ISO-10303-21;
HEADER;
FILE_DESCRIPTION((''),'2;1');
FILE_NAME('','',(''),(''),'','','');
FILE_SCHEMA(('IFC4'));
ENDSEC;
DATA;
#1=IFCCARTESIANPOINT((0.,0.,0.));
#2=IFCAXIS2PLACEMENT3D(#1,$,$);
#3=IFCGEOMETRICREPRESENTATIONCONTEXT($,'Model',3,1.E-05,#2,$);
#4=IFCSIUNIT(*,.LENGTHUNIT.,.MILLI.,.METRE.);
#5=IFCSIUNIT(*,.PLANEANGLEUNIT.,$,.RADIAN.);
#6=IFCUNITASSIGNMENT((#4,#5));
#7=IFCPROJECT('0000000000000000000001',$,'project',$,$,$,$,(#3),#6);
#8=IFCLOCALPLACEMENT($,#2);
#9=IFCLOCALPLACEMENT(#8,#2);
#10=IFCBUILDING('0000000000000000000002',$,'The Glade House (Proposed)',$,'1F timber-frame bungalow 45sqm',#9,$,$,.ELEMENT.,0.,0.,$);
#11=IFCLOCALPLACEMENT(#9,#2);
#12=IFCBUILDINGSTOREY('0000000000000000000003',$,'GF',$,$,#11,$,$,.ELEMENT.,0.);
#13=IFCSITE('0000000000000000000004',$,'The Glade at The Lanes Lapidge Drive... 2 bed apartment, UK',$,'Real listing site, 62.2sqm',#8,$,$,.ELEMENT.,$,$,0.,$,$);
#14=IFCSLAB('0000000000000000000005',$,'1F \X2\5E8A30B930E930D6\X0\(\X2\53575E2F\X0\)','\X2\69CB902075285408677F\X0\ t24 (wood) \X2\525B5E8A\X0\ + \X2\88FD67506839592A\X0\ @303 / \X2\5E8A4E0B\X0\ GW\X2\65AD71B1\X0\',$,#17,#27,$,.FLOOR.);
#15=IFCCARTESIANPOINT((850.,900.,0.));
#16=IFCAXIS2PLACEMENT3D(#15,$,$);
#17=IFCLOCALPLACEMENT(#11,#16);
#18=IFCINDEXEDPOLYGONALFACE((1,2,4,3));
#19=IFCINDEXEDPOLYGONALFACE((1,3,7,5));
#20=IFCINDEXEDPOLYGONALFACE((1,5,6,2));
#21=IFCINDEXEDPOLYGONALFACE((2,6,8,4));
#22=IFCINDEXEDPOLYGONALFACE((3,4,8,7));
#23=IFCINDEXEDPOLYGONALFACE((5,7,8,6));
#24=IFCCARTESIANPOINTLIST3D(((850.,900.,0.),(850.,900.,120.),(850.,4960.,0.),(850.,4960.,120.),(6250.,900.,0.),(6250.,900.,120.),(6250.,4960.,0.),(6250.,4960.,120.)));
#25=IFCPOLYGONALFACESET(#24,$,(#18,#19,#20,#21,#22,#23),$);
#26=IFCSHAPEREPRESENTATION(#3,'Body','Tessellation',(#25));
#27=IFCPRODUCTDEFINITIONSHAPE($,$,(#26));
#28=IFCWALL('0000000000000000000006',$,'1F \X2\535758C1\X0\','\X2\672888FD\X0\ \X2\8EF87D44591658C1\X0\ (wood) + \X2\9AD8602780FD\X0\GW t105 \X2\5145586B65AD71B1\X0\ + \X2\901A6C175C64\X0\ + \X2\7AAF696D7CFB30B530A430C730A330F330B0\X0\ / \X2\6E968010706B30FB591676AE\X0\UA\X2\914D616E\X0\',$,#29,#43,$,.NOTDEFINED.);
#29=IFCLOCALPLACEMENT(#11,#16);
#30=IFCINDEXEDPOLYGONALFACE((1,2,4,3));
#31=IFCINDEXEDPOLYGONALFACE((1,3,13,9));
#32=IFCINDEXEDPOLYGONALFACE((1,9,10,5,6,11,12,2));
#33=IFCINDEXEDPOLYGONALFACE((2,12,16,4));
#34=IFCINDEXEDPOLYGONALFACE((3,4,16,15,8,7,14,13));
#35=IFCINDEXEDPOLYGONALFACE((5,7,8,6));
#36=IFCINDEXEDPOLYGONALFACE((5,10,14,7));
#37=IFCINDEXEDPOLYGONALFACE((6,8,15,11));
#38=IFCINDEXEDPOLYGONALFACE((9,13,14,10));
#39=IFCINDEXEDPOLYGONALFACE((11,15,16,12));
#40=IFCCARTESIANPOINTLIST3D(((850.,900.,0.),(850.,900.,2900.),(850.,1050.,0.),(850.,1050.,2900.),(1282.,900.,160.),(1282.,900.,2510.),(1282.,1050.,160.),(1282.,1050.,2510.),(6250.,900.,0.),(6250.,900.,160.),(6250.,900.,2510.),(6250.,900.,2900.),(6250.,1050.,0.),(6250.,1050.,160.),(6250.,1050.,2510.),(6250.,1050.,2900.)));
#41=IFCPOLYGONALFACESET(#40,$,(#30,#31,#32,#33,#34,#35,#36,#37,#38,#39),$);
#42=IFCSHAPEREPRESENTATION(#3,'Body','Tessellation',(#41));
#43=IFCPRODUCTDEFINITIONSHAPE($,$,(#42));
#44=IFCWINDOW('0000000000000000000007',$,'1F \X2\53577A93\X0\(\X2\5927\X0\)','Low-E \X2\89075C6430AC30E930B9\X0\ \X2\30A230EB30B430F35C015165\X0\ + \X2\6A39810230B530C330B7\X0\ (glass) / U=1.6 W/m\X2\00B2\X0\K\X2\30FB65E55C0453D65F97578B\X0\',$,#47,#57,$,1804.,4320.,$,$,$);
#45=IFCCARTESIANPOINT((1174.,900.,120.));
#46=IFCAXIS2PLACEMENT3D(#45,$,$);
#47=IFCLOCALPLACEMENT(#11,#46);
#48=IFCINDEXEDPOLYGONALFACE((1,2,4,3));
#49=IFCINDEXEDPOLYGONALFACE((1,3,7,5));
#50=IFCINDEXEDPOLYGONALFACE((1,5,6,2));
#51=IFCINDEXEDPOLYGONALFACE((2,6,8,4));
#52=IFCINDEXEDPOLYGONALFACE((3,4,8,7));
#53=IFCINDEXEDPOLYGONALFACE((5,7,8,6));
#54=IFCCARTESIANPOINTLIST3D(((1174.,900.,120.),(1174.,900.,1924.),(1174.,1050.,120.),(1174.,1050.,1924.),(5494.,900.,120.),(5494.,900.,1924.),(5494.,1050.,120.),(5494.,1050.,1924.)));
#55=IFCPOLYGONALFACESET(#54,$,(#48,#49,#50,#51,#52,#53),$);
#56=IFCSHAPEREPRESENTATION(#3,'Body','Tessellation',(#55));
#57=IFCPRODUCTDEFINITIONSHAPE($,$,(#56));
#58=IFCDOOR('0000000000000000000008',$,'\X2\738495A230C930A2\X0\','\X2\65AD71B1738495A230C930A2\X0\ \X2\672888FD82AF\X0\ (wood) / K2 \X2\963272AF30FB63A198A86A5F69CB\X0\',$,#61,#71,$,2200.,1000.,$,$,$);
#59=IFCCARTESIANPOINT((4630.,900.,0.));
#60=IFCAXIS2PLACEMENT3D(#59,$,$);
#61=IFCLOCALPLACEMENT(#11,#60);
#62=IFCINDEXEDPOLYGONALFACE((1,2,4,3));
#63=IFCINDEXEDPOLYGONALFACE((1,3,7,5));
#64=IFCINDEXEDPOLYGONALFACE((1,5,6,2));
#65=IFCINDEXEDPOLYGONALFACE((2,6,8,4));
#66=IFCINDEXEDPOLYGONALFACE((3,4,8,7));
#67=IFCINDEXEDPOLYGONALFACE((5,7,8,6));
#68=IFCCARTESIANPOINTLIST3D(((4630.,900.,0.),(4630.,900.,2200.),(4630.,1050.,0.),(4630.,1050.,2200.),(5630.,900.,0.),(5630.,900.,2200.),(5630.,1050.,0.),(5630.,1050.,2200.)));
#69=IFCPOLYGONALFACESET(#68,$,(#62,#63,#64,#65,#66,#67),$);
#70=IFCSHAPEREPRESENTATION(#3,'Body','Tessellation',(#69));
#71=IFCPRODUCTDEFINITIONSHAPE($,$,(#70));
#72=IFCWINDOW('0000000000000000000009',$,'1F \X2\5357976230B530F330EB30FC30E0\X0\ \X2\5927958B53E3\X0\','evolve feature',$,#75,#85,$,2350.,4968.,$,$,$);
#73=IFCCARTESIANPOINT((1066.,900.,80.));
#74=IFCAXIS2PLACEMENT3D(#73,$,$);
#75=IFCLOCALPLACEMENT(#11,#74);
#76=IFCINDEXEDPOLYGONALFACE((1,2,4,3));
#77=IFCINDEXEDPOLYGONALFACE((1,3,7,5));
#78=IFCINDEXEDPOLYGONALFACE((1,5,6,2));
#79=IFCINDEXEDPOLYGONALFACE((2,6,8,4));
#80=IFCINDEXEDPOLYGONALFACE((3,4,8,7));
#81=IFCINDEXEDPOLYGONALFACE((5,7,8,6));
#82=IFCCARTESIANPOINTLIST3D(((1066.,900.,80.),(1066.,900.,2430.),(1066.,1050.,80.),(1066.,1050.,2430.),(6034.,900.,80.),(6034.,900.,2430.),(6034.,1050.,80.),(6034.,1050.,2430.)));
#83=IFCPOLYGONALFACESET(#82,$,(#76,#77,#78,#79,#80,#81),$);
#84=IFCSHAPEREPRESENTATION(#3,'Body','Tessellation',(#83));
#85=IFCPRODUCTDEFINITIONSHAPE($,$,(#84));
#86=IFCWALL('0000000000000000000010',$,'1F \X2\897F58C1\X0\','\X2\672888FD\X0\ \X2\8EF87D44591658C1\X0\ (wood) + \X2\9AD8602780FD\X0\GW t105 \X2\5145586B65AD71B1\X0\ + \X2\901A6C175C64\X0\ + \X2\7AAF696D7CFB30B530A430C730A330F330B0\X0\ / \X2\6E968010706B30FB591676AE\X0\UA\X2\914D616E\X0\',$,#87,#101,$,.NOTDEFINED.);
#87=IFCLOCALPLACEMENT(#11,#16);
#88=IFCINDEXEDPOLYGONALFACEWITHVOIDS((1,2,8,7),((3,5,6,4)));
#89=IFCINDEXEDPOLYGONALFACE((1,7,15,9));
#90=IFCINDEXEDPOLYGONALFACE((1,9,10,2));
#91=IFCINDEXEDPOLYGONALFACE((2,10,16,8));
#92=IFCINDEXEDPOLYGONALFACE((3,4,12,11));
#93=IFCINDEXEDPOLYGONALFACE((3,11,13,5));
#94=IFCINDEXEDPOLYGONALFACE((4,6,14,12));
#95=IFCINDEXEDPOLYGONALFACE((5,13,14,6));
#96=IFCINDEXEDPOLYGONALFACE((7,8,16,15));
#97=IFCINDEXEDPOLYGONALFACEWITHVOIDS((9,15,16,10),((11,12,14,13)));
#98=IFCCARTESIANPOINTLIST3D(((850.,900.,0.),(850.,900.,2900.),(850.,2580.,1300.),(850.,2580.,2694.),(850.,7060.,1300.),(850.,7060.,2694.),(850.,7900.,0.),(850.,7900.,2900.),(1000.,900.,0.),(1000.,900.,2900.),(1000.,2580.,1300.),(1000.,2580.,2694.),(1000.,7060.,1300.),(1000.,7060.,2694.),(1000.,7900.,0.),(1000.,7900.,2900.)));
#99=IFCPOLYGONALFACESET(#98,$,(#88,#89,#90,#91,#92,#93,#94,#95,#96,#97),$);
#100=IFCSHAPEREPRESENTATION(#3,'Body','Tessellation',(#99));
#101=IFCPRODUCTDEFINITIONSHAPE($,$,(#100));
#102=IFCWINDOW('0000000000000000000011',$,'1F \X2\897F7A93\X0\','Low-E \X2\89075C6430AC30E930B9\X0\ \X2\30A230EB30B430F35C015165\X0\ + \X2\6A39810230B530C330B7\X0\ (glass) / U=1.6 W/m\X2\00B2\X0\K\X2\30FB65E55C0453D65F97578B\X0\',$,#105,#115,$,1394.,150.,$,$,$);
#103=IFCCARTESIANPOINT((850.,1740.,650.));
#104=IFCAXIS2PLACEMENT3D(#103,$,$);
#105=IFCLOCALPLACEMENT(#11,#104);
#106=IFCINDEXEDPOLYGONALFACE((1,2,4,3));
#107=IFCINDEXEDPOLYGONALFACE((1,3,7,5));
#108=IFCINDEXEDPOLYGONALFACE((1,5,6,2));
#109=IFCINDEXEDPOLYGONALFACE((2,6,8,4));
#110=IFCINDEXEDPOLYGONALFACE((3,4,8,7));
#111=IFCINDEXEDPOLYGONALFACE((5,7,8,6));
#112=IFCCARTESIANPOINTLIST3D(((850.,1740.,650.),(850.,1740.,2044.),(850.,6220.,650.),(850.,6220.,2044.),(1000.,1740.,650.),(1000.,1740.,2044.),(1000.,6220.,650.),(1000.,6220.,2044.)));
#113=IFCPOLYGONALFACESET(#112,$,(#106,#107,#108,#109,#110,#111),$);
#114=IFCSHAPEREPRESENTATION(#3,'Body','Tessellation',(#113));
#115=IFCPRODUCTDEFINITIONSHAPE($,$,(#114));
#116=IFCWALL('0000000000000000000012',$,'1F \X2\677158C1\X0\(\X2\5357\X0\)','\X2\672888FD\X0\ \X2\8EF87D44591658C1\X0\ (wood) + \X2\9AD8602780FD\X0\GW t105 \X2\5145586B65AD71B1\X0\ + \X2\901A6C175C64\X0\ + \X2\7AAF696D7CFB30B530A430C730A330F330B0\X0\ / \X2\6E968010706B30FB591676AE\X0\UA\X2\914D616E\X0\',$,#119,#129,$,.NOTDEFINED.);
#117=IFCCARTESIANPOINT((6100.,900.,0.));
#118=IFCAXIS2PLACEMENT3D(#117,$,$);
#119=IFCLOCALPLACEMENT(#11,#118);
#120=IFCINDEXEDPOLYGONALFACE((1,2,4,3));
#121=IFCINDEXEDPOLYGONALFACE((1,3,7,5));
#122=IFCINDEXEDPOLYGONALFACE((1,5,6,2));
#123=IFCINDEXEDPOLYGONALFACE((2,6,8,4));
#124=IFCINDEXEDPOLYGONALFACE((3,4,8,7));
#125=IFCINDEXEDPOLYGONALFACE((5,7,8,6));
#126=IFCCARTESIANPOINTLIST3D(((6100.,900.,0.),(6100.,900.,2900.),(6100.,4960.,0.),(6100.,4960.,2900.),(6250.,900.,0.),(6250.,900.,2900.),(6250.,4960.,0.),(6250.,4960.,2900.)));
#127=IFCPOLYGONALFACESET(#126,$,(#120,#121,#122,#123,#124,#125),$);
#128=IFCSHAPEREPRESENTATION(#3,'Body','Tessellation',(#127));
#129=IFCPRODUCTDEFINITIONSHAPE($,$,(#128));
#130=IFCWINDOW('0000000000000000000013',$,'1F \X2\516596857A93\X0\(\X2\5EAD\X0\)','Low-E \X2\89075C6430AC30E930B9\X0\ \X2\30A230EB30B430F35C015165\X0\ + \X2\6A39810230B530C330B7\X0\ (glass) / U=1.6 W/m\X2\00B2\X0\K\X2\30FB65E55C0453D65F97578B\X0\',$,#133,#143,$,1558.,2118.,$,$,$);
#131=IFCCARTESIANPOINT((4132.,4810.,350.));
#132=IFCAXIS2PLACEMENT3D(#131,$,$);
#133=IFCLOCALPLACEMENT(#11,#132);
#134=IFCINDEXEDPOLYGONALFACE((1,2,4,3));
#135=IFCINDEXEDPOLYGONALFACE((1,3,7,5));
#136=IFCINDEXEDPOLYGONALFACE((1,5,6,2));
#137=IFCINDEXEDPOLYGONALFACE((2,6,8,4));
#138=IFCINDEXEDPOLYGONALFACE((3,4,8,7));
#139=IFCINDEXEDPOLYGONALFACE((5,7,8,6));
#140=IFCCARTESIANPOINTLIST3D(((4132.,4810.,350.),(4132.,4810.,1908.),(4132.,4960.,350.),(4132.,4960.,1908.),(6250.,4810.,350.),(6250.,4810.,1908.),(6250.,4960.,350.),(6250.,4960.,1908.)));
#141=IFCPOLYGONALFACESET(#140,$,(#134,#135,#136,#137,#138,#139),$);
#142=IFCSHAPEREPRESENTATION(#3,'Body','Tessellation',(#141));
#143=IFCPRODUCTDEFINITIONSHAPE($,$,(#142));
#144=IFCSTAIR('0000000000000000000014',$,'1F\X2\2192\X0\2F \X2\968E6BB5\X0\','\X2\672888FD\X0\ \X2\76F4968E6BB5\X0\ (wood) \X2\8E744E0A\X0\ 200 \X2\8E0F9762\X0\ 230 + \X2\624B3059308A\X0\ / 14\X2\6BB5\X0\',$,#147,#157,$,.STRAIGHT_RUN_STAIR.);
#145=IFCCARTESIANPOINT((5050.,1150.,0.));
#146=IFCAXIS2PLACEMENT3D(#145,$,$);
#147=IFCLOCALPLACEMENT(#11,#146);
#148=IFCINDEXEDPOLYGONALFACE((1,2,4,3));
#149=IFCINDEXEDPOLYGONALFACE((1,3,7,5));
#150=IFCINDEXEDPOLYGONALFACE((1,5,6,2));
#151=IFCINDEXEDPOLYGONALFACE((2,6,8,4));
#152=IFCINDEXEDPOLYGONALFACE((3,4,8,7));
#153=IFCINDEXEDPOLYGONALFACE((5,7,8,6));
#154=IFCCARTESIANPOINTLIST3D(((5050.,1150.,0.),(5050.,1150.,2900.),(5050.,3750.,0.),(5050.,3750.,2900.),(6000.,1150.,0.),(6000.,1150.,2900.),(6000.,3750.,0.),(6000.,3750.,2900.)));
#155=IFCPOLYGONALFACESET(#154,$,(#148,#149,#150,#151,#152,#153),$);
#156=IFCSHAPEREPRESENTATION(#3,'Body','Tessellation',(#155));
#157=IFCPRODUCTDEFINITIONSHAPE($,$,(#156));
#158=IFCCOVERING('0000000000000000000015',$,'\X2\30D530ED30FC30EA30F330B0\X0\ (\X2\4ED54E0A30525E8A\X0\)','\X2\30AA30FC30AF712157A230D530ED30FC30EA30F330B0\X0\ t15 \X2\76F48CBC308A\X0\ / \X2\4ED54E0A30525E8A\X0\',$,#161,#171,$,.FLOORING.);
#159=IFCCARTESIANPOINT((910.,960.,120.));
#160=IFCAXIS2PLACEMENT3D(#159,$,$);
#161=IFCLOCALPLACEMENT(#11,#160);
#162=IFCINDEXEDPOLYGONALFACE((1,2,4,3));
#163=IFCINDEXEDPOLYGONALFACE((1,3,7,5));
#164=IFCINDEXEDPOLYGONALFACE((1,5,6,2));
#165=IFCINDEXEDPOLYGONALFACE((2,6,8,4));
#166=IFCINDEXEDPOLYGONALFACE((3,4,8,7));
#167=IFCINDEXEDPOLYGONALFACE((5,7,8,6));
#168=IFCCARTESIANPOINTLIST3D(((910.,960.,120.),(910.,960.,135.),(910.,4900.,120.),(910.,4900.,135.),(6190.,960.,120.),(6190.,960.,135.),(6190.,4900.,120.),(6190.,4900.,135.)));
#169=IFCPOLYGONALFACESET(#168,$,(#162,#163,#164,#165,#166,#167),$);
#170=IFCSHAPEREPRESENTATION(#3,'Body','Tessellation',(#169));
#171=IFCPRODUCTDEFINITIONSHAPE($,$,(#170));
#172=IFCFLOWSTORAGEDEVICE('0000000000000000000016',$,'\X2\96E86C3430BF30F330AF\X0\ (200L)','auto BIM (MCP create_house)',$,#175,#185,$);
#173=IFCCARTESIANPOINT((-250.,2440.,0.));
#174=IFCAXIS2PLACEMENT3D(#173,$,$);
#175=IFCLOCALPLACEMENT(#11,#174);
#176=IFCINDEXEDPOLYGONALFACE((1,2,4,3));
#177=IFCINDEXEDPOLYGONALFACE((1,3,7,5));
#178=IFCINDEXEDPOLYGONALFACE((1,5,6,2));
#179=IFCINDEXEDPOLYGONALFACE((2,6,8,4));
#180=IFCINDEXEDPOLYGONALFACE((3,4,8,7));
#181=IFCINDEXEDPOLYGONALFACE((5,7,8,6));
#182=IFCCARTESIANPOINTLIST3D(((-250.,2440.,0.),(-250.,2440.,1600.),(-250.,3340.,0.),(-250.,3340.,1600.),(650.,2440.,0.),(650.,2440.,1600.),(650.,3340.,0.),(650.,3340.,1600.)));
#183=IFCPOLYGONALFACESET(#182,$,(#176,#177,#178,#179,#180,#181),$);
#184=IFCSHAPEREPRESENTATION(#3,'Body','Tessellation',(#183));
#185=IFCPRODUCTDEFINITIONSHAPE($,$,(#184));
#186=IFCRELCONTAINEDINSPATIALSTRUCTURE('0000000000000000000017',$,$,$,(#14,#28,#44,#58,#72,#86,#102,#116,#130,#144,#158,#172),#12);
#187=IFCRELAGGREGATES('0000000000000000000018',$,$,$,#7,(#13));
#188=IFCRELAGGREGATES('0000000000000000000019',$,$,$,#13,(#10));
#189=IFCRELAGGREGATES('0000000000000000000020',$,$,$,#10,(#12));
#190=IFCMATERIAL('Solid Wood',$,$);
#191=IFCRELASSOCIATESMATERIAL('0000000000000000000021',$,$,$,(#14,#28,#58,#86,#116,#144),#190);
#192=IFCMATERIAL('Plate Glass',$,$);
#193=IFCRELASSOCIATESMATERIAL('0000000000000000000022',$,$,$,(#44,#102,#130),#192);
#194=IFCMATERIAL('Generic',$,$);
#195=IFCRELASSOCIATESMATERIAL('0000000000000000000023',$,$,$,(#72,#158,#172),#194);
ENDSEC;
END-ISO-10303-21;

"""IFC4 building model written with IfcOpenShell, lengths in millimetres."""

from ifc_helpers import new_model, si_unit, frame, frame_2d, origin, place, context, project, spatial, rectangle, extrude, material, element, fill, save


model = new_model("IFC4")

# Units and contexts
model_context = context("Model", 3, precision=1e-05, world=origin())
ifc_project = project(units=[si_unit("LENGTHUNIT", "METRE", prefix="MILLI"), si_unit("PLANEANGLEUNIT", "RADIAN")], contexts=[model_context])

# Site, building, storey
site_placement = place(None, origin())
site = spatial("IfcSite", under=ifc_project, at=site_placement, Name="The Glade at The Lanes Lapidge Drive... 2 bed apartment, UK", ObjectType="Real listing site, 62.2sqm", CompositionType="ELEMENT", RefElevation=0.0)
building_placement = place(site_placement, origin())
building = spatial("IfcBuilding", under=site, at=building_placement, Name="The Glade House (Proposed)", ObjectType="1F timber-frame bungalow 45sqm", CompositionType="ELEMENT", ElevationOfRefHeight=0.0, ElevationOfTerrain=0.0)
storey_placement = place(building_placement, origin())
storey = spatial("IfcBuildingStorey", under=building, at=storey_placement, Name="GF", CompositionType="ELEMENT", Elevation=0.0)

# Slab
ifc_material_1 = material(Name="Solid Wood")
slab_1_placement = place(storey_placement, frame((850.0, 900.0, 0.0)))
element("IfcSlab", 1, at=slab_1_placement, inside=storey, material=ifc_material_1, Name="1F 床スラブ(南帯)", Description="構造用合板 t24 (wood) 剛床 + 製材根太 @303 / 床下 GW断熱", PredefinedType="FLOOR", context=model_context, shape_type="SweptSolid", body=[
    extrude(rectangle(XDim=5400.0, YDim=4060.0, at=frame_2d((2700.0, 2030.0))), frame((850.0, 900.0, 0.0)), (0.0, 0.0, 1.0), 120.0),
])

# Wall, openings, windows, door
wall_1_placement = place(storey_placement, frame((850.0, 900.0, 0.0)))
wall_1 = element("IfcWall", 2, at=wall_1_placement, inside=storey, material=ifc_material_1, Name="1F 南壁", Description="木製 軸組外壁 (wood) + 高性能GW t105 充填断熱 + 通気層 + 窯業系サイディング / 準耐火・外皮UA配慮", PredefinedType="NOTDEFINED", context=model_context, shape_type="SweptSolid", body=[
    extrude(rectangle(XDim=5400.0, YDim=150.0, at=frame_2d((2700.0, 75.0))), frame((850.0, 900.0, 0.0)), (0.0, 0.0, 1.0), 2900.0),
])
opening_1_placement = place(storey_placement, frame((1174.0, 900.0, 120.0)))
opening_1 = element("IfcOpeningElement", 3, at=opening_1_placement, cuts=wall_1, PredefinedType="NOTDEFINED", context=model_context, shape_type="SweptSolid", body=[
    extrude(rectangle(XDim=4320.0, YDim=150.0, at=frame_2d((2160.0, 75.0))), frame((1174.0, 900.0, 120.0)), (0.0, 0.0, 1.0), 1804.0),
])
opening_2_placement = place(storey_placement, frame((4630.0, 900.0, 0.0)))
opening_2 = element("IfcOpeningElement", 4, at=opening_2_placement, cuts=wall_1, PredefinedType="NOTDEFINED", context=model_context, shape_type="SweptSolid", body=[
    extrude(rectangle(XDim=1000.0, YDim=150.0, at=frame_2d((500.0, 75.0))), frame((4630.0, 900.0, 0.0)), (0.0, 0.0, 1.0), 2200.0),
])
opening_3_placement = place(storey_placement, frame((1066.0, 900.0, 80.0)))
opening_3 = element("IfcOpeningElement", 5, at=opening_3_placement, cuts=wall_1, PredefinedType="NOTDEFINED", context=model_context, shape_type="SweptSolid", body=[
    extrude(rectangle(XDim=4968.0, YDim=150.0, at=frame_2d((2484.0, 75.0))), frame((1066.0, 900.0, 80.0)), (0.0, 0.0, 1.0), 2350.0),
])
ifc_material_2 = material(Name="Plate Glass")
window_1_placement = place(storey_placement, frame((1174.0, 900.0, 120.0)))
window_1 = element("IfcWindow", 6, at=window_1_placement, inside=storey, material=ifc_material_2, Name="1F 南窓(大)", Description="Low-E 複層ガラス アルゴン封入 + 樹脂サッシ (glass) / U=1.6 W/m²K・日射取得型", OverallHeight=1804.0, OverallWidth=4320.0, context=model_context, shape_type="SweptSolid", body=[
    extrude(rectangle(XDim=4320.0, YDim=150.0, at=frame_2d((2160.0, 75.0))), frame((1174.0, 900.0, 120.0)), (0.0, 0.0, 1.0), 1804.0),
])
fill(opening_1, window_1)
door_1_placement = place(storey_placement, frame((4630.0, 900.0, 0.0)))
door_1 = element("IfcDoor", 7, at=door_1_placement, inside=storey, material=ifc_material_1, Name="玄関ドア", Description="断熱玄関ドア 木製芯 (wood) / K2 防犯・採風機構", OverallHeight=2200.0, OverallWidth=1000.0, context=model_context, shape_type="SweptSolid", body=[
    extrude(rectangle(XDim=1000.0, YDim=150.0, at=frame_2d((500.0, 75.0))), frame((4630.0, 900.0, 0.0)), (0.0, 0.0, 1.0), 2200.0),
])
fill(opening_2, door_1)
ifc_material_3 = material(Name="Generic")
window_2_placement = place(storey_placement, frame((1066.0, 900.0, 80.0)))
window_2 = element("IfcWindow", 8, at=window_2_placement, inside=storey, material=ifc_material_3, Name="1F 南面サンルーム 大開口", Description="evolve feature", OverallHeight=2350.0, OverallWidth=4968.0, context=model_context, shape_type="SweptSolid", body=[
    extrude(rectangle(XDim=4968.0, YDim=150.0, at=frame_2d((2484.0, 75.0))), frame((1066.0, 900.0, 80.0)), (0.0, 0.0, 1.0), 2350.0),
])
fill(opening_3, window_2)

# Walls, openings, windows
wall_2_placement = place(storey_placement, frame((850.0, 900.0, 0.0)))
wall_2 = element("IfcWall", 9, at=wall_2_placement, inside=storey, material=ifc_material_1, Name="1F 西壁", Description="木製 軸組外壁 (wood) + 高性能GW t105 充填断熱 + 通気層 + 窯業系サイディング / 準耐火・外皮UA配慮", PredefinedType="NOTDEFINED", context=model_context, shape_type="SweptSolid", body=[
    extrude(rectangle(XDim=150.0, YDim=7000.0, at=frame_2d((75.0, 3500.0))), frame((850.0, 900.0, 0.0)), (0.0, 0.0, 1.0), 2900.0),
])
opening_4_placement = place(storey_placement, frame((850.0, 1740.0, 650.0)))
opening_4 = element("IfcOpeningElement", 10, at=opening_4_placement, cuts=wall_2, PredefinedType="NOTDEFINED", context=model_context, shape_type="SweptSolid", body=[
    extrude(rectangle(XDim=150.0, YDim=4480.0, at=frame_2d((75.0, 2240.0))), frame((850.0, 1740.0, 650.0)), (0.0, 0.0, 1.0), 1394.0),
])
window_3_placement = place(storey_placement, frame((850.0, 1740.0, 650.0)))
window_3 = element("IfcWindow", 11, at=window_3_placement, inside=storey, material=ifc_material_2, Name="1F 西窓", Description="Low-E 複層ガラス アルゴン封入 + 樹脂サッシ (glass) / U=1.6 W/m²K・日射取得型", OverallHeight=1394.0, OverallWidth=150.0, context=model_context, shape_type="SweptSolid", body=[
    extrude(rectangle(XDim=150.0, YDim=4480.0, at=frame_2d((75.0, 2240.0))), frame((850.0, 1740.0, 650.0)), (0.0, 0.0, 1.0), 1394.0),
])
fill(opening_4, window_3)
wall_3_placement = place(storey_placement, frame((6100.0, 900.0, 0.0)))
wall_3 = element("IfcWall", 12, at=wall_3_placement, inside=storey, material=ifc_material_1, Name="1F 東壁(南)", Description="木製 軸組外壁 (wood) + 高性能GW t105 充填断熱 + 通気層 + 窯業系サイディング / 準耐火・外皮UA配慮", PredefinedType="NOTDEFINED", context=model_context, shape_type="SweptSolid", body=[
    extrude(rectangle(XDim=150.0, YDim=4060.0, at=frame_2d((75.0, 2030.0))), frame((6100.0, 900.0, 0.0)), (0.0, 0.0, 1.0), 2900.0),
])
opening_5_placement = place(storey_placement, frame((4132.0, 4810.0, 350.0)))
opening_5 = element("IfcOpeningElement", 13, at=opening_5_placement, cuts=wall_3, PredefinedType="NOTDEFINED", context=model_context, shape_type="SweptSolid", body=[
    extrude(rectangle(XDim=2118.0, YDim=150.0, at=frame_2d((1059.0, 75.0))), frame((4132.0, 4810.0, 350.0)), (0.0, 0.0, 1.0), 1558.0),
])
window_4_placement = place(storey_placement, frame((4132.0, 4810.0, 350.0)))
window_4 = element("IfcWindow", 14, at=window_4_placement, inside=storey, material=ifc_material_2, Name="1F 入隅窓(庭)", Description="Low-E 複層ガラス アルゴン封入 + 樹脂サッシ (glass) / U=1.6 W/m²K・日射取得型", OverallHeight=1558.0, OverallWidth=2118.0, context=model_context, shape_type="SweptSolid", body=[
    extrude(rectangle(XDim=2118.0, YDim=150.0, at=frame_2d((1059.0, 75.0))), frame((4132.0, 4810.0, 350.0)), (0.0, 0.0, 1.0), 1558.0),
])
fill(opening_5, window_4)

# Stair
stair_placement = place(storey_placement, frame((5050.0, 1150.0, 0.0)))
element("IfcStair", 15, at=stair_placement, inside=storey, material=ifc_material_1, Name="1F→2F 階段", Description="木製 直階段 (wood) 蹴上 200 踏面 230 + 手すり / 14段", PredefinedType="STRAIGHT_RUN_STAIR", context=model_context, shape_type="SweptSolid", body=[
    extrude(rectangle(XDim=950.0, YDim=2600.0, at=frame_2d((475.0, 1300.0))), frame((5050.0, 1150.0, 0.0)), (0.0, 0.0, 1.0), 2900.0),
])

# Covering
covering_placement = place(storey_placement, frame((910.0, 960.0, 120.0)))
element("IfcCovering", 16, at=covering_placement, inside=storey, material=ifc_material_3, Name="フローリング (仕上げ床)", Description="オーク無垢フローリング t15 直貼り / 仕上げ床", PredefinedType="FLOORING", context=model_context, shape_type="SweptSolid", body=[
    extrude(rectangle(XDim=5280.0, YDim=3940.0, at=frame_2d((2640.0, 1970.0))), frame((910.0, 960.0, 120.0)), (0.0, 0.0, 1.0), 15.0),
])

# Flow storage device
flow_storage_device_placement = place(storey_placement, frame((-250.0, 2440.0, 0.0)))
element("IfcFlowStorageDevice", 17, at=flow_storage_device_placement, inside=storey, material=ifc_material_3, Name="雨水タンク (200L)", Description="auto BIM (MCP create_house)", context=model_context, shape_type="SweptSolid", body=[
    extrude(rectangle(XDim=900.0, YDim=900.0, at=frame_2d((450.0, 450.0))), frame((-250.0, 2440.0, 0.0)), (0.0, 0.0, 1.0), 1600.0),
])

save(model, "model.ifc")
